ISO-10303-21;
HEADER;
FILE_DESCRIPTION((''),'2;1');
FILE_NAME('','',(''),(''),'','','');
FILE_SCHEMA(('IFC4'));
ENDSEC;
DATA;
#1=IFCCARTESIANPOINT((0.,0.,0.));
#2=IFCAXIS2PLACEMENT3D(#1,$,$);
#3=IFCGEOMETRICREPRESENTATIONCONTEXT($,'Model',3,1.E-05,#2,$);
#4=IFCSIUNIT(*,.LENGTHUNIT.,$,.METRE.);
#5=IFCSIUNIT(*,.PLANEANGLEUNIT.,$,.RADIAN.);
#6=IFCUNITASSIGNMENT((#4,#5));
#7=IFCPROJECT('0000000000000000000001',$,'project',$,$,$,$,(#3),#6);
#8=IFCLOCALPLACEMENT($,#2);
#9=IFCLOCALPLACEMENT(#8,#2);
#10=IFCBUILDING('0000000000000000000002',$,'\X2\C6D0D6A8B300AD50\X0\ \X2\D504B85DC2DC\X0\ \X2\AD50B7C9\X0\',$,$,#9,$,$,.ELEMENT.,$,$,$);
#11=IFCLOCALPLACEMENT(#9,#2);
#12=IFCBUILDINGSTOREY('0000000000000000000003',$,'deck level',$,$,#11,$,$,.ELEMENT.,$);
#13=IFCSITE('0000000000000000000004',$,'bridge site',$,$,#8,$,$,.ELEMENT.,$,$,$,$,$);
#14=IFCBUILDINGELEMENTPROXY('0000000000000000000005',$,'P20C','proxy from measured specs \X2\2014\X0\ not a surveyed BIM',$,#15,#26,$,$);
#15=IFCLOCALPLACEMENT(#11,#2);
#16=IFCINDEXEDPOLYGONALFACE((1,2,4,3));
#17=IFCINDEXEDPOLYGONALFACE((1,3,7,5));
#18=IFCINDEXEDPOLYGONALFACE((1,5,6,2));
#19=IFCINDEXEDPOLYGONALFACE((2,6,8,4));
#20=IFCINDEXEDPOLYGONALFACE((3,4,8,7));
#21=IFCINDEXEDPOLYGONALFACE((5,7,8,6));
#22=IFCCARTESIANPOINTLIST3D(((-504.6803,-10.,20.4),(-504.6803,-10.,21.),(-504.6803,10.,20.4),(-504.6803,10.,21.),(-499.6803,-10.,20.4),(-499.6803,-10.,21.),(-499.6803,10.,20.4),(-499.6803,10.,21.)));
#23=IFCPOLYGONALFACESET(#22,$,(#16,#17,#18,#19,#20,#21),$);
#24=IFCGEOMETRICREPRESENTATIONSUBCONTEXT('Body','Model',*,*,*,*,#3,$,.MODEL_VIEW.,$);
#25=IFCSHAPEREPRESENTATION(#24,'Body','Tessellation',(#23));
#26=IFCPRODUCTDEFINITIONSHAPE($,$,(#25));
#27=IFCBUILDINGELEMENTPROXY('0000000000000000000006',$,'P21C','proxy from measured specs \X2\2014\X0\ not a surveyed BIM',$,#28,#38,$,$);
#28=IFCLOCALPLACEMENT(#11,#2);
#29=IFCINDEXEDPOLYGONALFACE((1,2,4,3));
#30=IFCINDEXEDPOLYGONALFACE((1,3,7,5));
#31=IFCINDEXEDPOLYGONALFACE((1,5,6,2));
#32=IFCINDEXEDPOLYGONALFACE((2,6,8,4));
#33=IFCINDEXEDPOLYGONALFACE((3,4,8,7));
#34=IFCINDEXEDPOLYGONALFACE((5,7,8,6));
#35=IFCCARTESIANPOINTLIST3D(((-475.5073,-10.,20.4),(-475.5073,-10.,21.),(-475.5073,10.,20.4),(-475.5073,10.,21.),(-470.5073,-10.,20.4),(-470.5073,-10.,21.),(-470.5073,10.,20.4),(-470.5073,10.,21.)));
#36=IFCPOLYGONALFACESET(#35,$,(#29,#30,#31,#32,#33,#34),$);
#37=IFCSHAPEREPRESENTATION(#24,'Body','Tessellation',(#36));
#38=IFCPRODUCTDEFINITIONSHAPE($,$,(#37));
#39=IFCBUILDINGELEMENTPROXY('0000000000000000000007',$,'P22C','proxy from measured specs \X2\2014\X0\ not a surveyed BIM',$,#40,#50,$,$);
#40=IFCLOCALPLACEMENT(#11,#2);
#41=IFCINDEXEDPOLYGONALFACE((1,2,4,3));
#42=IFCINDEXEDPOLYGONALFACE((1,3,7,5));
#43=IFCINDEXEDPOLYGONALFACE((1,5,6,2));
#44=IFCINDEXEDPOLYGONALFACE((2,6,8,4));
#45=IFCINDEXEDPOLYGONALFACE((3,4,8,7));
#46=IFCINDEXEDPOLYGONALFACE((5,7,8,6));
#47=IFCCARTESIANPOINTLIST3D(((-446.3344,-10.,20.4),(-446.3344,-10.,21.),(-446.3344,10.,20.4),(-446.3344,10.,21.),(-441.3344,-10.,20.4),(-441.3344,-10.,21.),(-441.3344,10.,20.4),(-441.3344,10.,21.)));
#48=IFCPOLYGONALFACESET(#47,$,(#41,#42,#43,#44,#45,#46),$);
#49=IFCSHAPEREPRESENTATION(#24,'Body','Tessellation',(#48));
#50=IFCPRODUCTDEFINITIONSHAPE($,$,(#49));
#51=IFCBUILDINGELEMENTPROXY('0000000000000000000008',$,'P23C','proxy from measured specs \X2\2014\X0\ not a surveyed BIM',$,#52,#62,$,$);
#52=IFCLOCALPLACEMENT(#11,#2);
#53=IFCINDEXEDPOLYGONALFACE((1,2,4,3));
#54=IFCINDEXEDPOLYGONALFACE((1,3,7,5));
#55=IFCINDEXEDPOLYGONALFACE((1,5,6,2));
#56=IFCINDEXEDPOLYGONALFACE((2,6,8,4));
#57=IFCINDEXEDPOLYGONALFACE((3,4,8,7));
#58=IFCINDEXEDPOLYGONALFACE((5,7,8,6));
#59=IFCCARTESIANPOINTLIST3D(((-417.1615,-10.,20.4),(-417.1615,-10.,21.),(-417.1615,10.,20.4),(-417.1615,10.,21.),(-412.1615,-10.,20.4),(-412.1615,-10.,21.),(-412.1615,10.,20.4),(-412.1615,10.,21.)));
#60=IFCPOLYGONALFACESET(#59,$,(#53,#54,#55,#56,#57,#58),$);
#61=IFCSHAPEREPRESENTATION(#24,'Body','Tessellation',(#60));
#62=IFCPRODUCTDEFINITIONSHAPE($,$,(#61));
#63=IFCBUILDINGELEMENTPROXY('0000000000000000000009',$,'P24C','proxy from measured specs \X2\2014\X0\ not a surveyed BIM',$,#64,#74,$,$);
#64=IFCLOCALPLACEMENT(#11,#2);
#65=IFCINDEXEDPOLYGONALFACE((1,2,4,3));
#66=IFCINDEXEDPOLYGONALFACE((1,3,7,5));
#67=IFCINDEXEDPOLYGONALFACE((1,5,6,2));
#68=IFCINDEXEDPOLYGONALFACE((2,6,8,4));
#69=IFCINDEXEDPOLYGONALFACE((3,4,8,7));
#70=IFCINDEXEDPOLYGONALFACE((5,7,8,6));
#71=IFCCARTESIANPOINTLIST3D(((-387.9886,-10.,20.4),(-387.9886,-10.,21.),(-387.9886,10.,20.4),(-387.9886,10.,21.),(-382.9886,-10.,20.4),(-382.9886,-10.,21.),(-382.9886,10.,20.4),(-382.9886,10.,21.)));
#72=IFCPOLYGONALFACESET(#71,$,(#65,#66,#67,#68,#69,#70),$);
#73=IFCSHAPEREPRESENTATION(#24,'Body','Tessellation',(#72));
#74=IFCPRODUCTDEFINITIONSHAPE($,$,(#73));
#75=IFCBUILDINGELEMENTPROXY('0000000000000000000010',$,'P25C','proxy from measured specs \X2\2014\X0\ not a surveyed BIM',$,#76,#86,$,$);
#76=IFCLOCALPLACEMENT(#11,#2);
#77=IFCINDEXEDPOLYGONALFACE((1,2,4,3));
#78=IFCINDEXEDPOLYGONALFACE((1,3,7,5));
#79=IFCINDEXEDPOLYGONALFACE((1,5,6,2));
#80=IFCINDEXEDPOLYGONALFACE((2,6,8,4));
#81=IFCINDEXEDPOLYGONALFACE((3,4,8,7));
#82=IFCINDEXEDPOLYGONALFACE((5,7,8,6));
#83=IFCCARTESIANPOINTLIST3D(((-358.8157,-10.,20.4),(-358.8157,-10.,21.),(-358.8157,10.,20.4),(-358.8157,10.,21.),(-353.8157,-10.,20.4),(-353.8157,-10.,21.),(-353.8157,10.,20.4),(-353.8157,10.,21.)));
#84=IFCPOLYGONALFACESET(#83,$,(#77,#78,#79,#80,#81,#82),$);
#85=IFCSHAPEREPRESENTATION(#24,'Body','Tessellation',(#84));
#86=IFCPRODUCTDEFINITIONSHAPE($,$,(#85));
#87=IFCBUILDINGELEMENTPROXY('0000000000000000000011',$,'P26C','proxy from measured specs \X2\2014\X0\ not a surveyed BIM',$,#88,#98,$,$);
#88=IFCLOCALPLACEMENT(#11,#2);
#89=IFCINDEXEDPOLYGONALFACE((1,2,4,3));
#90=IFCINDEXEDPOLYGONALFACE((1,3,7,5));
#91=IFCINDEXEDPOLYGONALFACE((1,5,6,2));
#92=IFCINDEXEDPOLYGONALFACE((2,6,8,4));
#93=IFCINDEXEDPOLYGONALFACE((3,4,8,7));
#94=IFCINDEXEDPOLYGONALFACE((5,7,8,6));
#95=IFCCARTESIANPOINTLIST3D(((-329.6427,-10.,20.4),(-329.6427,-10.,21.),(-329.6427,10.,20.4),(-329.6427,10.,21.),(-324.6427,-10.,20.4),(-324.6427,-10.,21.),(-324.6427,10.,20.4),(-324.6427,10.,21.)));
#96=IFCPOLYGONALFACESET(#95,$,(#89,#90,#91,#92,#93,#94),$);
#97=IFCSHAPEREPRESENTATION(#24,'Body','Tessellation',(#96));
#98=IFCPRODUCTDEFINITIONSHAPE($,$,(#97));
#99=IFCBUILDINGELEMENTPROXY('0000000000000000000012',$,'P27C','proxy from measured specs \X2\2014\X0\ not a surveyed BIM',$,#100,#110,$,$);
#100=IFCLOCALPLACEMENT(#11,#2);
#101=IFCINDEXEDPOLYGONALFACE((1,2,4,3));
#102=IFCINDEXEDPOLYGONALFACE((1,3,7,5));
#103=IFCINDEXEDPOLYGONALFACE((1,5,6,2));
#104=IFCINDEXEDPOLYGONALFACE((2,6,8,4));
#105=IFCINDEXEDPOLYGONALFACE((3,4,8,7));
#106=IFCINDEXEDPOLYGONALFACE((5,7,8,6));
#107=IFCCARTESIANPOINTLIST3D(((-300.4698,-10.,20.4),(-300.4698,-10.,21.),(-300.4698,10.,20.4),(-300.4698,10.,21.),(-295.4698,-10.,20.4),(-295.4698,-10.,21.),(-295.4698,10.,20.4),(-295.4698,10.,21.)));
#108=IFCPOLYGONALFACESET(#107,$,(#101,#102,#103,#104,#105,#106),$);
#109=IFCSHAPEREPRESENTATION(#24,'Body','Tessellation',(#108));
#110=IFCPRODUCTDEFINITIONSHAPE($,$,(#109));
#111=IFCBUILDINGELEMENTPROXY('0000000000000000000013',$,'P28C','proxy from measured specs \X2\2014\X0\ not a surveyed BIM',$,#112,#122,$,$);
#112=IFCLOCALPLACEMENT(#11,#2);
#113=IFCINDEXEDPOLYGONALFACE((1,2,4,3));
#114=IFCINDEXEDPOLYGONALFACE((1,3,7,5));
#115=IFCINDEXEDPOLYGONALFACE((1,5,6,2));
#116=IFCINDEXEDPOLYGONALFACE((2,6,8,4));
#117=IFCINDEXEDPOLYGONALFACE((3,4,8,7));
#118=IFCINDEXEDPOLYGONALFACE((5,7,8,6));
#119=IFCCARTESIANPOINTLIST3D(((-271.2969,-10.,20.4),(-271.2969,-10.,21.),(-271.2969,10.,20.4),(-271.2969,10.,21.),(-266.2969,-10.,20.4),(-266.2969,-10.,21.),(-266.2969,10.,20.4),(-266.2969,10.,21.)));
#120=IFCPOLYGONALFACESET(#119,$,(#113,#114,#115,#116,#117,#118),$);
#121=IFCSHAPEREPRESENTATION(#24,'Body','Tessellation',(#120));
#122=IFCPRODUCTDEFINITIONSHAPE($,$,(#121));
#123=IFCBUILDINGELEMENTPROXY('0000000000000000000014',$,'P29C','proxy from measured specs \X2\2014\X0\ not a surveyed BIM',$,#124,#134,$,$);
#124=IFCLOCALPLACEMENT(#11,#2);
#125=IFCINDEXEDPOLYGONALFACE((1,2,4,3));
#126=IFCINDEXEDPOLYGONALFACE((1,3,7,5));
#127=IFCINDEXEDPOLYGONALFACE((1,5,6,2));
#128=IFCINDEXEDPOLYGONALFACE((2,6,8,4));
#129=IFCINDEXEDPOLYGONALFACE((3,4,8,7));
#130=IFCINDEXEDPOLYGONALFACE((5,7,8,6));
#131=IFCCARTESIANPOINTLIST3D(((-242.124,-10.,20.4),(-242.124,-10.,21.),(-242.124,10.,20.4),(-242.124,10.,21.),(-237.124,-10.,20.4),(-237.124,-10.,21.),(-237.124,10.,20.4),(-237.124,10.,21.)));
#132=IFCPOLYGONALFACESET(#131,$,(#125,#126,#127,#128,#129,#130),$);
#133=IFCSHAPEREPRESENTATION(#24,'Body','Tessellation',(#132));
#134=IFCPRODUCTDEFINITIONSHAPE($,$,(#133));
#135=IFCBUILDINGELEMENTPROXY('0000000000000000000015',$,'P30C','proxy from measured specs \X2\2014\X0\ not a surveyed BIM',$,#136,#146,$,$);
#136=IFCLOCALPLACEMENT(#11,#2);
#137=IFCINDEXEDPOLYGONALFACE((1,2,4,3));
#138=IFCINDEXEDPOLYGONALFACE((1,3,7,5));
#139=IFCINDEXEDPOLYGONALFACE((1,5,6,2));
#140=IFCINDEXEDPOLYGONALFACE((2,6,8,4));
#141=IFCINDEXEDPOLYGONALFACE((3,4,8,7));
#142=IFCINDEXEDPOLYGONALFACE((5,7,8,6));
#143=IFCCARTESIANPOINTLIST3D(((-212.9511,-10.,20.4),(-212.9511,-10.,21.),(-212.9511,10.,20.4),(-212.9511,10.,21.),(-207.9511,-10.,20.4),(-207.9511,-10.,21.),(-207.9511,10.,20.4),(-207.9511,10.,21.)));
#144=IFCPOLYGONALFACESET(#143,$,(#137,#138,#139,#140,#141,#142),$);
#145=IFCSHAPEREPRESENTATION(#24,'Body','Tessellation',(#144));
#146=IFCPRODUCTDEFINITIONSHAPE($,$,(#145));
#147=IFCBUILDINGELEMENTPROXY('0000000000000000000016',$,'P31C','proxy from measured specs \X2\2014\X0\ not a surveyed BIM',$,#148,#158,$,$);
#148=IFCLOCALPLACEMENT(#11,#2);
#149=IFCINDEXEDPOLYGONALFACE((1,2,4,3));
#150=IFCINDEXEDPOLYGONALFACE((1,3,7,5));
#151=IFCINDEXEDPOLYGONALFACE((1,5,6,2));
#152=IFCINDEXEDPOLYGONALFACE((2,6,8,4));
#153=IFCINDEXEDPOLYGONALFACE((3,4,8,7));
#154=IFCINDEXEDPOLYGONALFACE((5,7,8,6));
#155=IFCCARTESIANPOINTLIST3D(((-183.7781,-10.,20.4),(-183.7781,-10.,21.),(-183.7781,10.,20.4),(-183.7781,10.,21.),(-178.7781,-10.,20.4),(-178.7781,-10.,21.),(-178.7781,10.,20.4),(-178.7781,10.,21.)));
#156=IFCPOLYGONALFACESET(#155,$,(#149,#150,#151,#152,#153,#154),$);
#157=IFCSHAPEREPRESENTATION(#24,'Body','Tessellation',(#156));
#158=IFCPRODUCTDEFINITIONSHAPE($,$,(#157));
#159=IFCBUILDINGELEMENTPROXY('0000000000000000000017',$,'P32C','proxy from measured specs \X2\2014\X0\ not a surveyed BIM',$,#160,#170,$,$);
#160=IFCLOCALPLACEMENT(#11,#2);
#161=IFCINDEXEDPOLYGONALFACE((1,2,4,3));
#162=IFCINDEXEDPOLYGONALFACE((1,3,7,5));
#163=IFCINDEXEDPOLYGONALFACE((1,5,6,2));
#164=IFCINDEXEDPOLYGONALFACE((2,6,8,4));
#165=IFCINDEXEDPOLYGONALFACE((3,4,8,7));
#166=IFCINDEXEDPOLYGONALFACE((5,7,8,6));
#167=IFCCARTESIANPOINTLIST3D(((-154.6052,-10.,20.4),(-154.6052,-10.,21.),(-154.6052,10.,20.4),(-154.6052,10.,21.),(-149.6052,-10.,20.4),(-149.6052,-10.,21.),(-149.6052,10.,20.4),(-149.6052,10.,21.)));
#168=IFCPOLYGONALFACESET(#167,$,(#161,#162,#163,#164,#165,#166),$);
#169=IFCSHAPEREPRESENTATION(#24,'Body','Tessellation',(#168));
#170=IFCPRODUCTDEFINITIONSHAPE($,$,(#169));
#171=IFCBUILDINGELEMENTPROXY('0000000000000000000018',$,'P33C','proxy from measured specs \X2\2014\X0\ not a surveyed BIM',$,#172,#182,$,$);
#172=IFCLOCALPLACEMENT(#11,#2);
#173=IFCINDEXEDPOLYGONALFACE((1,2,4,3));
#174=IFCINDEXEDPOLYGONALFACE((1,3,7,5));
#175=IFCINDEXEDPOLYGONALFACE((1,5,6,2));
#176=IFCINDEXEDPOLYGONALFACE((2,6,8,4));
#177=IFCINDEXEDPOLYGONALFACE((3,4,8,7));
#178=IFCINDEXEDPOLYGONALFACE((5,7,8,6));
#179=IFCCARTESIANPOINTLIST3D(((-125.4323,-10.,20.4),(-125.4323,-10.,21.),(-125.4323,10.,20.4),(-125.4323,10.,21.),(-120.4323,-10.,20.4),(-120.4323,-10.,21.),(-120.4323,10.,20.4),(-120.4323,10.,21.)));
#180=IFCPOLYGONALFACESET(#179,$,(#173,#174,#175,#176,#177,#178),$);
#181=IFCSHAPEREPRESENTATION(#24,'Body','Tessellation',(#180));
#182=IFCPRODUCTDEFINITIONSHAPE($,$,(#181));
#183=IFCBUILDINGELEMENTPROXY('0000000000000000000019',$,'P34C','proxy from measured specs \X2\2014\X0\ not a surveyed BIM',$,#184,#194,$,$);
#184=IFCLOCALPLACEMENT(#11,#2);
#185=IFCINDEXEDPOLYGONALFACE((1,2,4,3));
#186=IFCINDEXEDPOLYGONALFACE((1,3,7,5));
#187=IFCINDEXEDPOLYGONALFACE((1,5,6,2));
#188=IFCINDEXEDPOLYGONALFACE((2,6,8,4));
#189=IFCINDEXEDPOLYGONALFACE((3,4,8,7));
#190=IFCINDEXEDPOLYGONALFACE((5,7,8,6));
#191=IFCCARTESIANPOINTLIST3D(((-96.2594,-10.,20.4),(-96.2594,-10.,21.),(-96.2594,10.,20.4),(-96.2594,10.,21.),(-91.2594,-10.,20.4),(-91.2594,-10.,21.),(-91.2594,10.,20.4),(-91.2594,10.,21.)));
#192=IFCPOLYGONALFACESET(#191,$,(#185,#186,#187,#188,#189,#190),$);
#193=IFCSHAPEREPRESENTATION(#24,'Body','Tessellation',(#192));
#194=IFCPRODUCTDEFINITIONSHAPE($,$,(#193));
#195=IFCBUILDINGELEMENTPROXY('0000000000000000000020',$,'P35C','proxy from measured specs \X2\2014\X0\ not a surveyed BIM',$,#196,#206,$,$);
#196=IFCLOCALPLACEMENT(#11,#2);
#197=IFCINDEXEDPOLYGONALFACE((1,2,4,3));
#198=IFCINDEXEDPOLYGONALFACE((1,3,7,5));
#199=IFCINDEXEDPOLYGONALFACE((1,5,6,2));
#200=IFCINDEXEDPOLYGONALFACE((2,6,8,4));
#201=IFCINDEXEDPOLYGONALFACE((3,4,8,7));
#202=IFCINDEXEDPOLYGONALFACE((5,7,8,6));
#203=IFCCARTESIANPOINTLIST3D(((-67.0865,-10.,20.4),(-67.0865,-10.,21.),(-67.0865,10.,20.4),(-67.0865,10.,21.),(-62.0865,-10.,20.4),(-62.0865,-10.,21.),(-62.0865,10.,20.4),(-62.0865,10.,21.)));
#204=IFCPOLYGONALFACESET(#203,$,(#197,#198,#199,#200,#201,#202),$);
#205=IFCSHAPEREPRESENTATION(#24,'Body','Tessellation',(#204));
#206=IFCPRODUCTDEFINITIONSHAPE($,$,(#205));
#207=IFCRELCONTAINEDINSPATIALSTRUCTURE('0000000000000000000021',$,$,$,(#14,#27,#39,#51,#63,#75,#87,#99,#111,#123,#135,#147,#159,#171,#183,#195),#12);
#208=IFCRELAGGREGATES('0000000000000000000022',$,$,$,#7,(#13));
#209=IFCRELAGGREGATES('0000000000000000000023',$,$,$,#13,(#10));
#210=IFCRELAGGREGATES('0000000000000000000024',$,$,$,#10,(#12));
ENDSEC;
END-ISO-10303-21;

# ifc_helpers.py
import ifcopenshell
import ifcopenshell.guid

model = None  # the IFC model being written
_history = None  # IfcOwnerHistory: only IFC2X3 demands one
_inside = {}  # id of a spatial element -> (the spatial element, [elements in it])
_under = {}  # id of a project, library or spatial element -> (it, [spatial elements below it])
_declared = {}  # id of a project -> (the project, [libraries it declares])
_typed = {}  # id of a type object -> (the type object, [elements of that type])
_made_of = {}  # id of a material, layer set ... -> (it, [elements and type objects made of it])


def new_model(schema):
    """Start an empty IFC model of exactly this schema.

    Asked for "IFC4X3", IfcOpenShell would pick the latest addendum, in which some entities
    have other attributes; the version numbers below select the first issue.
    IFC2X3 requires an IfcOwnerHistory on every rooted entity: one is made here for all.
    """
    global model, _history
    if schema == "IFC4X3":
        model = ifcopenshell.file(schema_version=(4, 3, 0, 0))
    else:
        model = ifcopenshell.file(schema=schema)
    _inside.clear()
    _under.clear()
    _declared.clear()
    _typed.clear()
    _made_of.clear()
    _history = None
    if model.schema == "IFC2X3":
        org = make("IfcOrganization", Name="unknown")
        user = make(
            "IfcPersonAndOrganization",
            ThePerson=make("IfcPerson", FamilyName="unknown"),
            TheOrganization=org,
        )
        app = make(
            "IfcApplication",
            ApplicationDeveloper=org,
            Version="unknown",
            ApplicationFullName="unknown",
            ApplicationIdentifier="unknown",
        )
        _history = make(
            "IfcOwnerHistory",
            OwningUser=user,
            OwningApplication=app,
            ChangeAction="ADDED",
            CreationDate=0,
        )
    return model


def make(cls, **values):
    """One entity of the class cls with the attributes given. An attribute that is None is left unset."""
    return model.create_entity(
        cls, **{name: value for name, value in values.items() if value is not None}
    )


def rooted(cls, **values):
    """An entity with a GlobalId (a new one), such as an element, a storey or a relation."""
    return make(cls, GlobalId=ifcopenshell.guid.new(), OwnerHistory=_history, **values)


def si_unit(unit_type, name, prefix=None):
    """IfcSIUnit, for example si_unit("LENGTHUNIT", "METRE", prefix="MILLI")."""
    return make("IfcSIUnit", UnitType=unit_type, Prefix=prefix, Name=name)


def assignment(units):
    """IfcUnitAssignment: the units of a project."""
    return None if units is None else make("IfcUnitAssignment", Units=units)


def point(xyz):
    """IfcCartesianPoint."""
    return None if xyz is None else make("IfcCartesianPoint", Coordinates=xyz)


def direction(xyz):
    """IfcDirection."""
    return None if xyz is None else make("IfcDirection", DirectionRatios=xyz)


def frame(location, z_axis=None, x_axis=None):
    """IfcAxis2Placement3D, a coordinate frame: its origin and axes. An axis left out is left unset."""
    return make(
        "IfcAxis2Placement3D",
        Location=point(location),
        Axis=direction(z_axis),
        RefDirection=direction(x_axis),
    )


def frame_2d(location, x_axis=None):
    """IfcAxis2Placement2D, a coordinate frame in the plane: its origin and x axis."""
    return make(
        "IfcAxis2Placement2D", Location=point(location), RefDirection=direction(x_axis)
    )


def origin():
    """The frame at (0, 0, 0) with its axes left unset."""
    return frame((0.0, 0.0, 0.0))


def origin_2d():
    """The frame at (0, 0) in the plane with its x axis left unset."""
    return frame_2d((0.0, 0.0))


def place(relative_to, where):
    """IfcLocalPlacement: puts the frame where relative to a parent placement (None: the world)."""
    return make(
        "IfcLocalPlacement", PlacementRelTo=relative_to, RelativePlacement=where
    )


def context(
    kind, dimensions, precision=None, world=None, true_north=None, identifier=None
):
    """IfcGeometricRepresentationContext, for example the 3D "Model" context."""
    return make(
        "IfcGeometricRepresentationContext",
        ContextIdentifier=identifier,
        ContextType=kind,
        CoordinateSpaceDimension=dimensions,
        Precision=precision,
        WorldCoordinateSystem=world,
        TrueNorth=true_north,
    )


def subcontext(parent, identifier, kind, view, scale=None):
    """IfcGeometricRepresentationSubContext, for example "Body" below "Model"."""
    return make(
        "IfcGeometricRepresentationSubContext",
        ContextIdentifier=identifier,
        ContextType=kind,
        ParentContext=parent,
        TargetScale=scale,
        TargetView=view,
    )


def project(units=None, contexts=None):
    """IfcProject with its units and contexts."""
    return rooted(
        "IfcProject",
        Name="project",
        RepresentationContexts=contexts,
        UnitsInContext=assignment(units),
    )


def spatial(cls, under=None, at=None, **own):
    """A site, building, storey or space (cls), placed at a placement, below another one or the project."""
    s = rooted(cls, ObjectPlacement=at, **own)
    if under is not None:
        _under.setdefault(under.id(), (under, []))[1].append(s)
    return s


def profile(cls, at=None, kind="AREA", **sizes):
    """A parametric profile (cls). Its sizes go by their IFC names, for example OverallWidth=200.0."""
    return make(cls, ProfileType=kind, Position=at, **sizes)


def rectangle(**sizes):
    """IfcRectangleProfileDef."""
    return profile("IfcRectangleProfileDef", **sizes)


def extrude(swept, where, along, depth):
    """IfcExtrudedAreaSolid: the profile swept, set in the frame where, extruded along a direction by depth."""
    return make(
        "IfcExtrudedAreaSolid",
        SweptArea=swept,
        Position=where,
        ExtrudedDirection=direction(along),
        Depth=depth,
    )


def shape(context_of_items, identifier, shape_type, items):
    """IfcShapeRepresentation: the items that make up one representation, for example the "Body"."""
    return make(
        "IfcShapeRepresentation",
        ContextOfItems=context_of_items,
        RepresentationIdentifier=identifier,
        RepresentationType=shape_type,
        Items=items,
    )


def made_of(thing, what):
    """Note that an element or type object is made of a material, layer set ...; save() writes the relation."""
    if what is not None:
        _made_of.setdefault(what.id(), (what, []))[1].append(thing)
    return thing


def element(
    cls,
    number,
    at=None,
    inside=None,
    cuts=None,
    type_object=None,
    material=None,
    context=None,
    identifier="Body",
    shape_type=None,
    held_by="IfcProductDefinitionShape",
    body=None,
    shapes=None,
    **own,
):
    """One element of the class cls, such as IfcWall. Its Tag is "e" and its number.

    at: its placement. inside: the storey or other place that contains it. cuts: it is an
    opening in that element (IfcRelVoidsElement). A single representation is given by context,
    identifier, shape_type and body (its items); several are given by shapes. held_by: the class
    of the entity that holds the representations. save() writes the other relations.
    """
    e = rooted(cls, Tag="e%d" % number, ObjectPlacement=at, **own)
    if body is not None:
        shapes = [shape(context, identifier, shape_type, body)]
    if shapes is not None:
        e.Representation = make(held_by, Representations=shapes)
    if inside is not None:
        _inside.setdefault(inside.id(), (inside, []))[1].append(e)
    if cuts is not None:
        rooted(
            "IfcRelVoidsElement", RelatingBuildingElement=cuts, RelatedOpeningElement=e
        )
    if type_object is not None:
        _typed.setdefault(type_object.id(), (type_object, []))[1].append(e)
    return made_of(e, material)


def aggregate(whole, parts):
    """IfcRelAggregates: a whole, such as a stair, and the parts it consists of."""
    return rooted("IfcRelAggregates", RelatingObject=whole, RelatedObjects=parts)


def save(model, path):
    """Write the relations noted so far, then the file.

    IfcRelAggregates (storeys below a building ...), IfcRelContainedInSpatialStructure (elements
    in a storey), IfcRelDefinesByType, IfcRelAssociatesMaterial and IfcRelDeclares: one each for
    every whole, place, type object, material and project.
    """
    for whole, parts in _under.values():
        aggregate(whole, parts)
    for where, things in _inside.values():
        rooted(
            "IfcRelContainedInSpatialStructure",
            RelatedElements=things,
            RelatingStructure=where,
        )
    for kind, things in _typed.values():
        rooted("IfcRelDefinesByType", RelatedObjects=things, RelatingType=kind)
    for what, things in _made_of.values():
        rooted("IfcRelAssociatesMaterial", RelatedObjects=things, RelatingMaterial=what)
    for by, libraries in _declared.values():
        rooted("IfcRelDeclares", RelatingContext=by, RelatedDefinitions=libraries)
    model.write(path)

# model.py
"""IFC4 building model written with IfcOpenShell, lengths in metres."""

from ifc_helpers import new_model, si_unit, frame, origin, origin_2d, place, context, subcontext, project, spatial, rectangle, extrude, element, save


model = new_model("IFC4")

# Units and contexts
model_context = context("Model", 3, precision=1e-05, world=origin())
body_context = subcontext(model_context, "Body", "Model", "MODEL_VIEW")
ifc_project = project(units=[si_unit("LENGTHUNIT", "METRE"), si_unit("PLANEANGLEUNIT", "RADIAN")], contexts=[model_context])

# Site, building, storey
site_placement = place(None, origin())
site = spatial("IfcSite", under=ifc_project, at=site_placement, Name="bridge site", CompositionType="ELEMENT")
building_placement = place(site_placement, origin())
building = spatial("IfcBuilding", under=site, at=building_placement, Name="원효대교 프록시 교량", CompositionType="ELEMENT")
storey_placement = place(building_placement, origin())
storey = spatial("IfcBuildingStorey", under=building, at=storey_placement, Name="deck level", CompositionType="ELEMENT")

# Building element proxies
for number, where, name in (
    (1, (-502.1803, 0.0, 20.4), "P20C"),
    (2, (-473.0073, 0.0, 20.4), "P21C"),
    (3, (-443.8344, 0.0, 20.4), "P22C"),
    (4, (-414.6615, 0.0, 20.4), "P23C"),
    (5, (-385.4886, 0.0, 20.4), "P24C"),
    (6, (-356.3157, 0.0, 20.4), "P25C"),
    (7, (-327.1427, 0.0, 20.4), "P26C"),
    (8, (-297.9698, 0.0, 20.4), "P27C"),
    (9, (-268.7969, 0.0, 20.4), "P28C"),
    (10, (-239.624, 0.0, 20.4), "P29C"),
    (11, (-210.4511, 0.0, 20.4), "P30C"),
    (12, (-181.2781, 0.0, 20.4), "P31C"),
    (13, (-152.1052, 0.0, 20.4), "P32C"),
    (14, (-122.9323, 0.0, 20.4), "P33C"),
    (15, (-93.7594, 0.0, 20.4), "P34C"),
    (16, (-64.5865, 0.0, 20.4), "P35C"),
):
    element("IfcBuildingElementProxy", number, at=place(storey_placement, frame(where)), inside=storey, Name=name, Description="proxy from measured specs — not a surveyed BIM", context=body_context, shape_type="SweptSolid", body=[
        extrude(rectangle(XDim=5.0, YDim=20.0, at=origin_2d()), origin(), (0.0, 0.0, 1.0), 0.6),
    ])

save(model, "model.ifc")
